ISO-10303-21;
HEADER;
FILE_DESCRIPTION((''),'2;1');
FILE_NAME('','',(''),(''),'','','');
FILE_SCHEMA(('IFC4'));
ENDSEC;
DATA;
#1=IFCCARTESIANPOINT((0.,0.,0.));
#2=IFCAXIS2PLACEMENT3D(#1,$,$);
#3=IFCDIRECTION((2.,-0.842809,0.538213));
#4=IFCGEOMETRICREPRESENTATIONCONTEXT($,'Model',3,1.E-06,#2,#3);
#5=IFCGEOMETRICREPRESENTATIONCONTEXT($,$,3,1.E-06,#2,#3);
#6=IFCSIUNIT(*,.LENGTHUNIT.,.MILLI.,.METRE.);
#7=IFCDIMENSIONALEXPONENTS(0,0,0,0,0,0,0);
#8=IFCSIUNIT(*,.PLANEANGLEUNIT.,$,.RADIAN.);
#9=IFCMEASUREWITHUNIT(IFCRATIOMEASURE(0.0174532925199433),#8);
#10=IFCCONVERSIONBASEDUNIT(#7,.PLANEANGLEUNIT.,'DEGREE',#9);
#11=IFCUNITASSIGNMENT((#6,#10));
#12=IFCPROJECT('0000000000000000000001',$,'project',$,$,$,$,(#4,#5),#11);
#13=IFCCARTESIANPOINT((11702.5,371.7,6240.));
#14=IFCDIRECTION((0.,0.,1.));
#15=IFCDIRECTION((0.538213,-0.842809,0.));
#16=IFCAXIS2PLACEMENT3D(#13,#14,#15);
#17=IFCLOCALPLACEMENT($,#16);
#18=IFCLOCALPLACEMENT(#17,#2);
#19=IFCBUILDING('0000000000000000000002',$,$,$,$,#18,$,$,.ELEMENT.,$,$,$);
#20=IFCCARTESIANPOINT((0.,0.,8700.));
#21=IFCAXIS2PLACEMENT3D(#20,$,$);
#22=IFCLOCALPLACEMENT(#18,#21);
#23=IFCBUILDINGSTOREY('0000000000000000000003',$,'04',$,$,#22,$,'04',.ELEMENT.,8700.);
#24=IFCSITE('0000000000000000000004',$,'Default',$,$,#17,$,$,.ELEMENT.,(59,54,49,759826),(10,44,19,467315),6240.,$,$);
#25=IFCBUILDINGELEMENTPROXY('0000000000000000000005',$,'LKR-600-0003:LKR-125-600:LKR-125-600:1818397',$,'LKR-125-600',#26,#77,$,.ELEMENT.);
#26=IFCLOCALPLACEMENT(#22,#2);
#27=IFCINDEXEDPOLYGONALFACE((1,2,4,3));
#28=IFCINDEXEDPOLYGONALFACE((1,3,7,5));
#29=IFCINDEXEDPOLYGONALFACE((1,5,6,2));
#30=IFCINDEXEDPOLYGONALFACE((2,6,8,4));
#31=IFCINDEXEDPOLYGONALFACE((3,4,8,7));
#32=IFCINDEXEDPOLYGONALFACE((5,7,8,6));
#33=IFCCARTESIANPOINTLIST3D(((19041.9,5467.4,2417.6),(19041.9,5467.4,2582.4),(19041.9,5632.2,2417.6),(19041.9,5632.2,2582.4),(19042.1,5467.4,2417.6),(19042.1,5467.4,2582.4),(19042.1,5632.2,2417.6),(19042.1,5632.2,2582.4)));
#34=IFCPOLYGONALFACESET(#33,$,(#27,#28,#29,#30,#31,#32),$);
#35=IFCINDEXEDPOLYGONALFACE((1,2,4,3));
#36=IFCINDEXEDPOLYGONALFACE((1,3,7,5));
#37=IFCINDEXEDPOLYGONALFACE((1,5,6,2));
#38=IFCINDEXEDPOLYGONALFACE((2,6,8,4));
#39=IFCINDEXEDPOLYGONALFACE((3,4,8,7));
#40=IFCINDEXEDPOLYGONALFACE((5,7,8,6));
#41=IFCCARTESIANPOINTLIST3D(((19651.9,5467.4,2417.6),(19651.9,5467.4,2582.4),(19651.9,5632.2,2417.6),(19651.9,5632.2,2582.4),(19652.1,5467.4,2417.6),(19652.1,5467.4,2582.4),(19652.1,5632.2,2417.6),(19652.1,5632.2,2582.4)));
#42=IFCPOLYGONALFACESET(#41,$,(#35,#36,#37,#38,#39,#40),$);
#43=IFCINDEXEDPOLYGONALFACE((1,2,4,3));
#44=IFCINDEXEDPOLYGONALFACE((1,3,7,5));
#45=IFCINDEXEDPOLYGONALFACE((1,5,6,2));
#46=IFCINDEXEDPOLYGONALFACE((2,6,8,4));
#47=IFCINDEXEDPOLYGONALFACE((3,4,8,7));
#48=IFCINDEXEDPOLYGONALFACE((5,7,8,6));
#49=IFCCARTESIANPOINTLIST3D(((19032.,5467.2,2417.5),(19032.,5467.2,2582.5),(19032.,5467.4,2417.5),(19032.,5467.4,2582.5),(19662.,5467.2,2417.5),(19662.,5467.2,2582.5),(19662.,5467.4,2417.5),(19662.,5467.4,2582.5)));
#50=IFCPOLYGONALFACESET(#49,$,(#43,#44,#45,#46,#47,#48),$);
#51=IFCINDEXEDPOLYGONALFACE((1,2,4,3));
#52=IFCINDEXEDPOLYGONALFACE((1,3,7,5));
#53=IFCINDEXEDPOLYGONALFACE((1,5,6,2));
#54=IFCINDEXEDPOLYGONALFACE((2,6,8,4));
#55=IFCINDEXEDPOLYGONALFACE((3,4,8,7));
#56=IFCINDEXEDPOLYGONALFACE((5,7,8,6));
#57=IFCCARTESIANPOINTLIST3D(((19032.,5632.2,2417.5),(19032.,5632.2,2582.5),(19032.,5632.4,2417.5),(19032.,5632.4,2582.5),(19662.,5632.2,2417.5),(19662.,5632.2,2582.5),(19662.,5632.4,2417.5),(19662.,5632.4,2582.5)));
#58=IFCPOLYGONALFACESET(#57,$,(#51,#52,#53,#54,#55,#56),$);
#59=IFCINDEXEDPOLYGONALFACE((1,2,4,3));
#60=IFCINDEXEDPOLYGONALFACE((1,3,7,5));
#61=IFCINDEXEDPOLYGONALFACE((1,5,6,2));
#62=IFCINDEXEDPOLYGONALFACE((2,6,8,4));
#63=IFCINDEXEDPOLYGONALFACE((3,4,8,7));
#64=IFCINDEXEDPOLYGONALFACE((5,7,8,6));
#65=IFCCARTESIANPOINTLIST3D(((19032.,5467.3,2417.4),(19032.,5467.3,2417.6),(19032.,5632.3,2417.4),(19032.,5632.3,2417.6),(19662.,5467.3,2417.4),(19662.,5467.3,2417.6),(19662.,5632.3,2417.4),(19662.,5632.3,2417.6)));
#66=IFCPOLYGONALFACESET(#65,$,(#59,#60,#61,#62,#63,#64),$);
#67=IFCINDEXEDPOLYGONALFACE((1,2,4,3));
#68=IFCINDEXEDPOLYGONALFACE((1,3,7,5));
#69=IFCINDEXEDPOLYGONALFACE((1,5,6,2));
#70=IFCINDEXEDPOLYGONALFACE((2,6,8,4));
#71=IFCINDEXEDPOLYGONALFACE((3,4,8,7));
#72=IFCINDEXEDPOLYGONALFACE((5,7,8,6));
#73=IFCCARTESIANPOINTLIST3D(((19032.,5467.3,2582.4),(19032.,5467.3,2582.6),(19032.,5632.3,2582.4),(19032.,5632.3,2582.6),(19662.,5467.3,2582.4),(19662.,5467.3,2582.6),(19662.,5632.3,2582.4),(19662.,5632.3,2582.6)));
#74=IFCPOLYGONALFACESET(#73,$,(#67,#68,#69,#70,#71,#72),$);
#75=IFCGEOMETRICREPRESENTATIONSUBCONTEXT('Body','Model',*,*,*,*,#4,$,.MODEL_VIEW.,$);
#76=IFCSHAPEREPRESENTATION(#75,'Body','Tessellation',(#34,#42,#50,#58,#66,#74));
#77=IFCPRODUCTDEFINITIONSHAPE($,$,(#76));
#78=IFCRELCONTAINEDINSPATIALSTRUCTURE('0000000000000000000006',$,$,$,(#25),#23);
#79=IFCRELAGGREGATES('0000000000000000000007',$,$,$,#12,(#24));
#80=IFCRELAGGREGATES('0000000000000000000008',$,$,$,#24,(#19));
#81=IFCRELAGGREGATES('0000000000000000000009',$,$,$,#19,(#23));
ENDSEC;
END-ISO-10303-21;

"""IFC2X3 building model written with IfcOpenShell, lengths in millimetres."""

from ifc_helpers import new_model, entity, si_unit, converted_unit, direction, frame, frame_2d, origin, place, context, subcontext, project, spatial, rectangle, extrude, source, transform, mapped, element, save


model = new_model("IFC2X3")

# Units and contexts
model_context = context("Model", 3, precision=1e-06, world=origin(), true_north=direction((2.0, -0.842809, 0.538213)))
context_of_model = context(None, 3, precision=1e-06, world=origin(), true_north=direction((2.0, -0.842809, 0.538213)))
body_context = subcontext(model_context, "Body", "Model", "MODEL_VIEW")
ifc_project = project(units=[si_unit("LENGTHUNIT", "METRE", prefix="MILLI"), converted_unit("PLANEANGLEUNIT", "DEGREE", entity("IfcRatioMeasure", 0.0174532925199433), si_unit("PLANEANGLEUNIT", "RADIAN"), dimensions=[0, 0, 0, 0, 0, 0, 0])], contexts=[model_context, context_of_model])

# Site, building, storey
site_placement = place(None, frame((11702.5, 371.7, 6240.0), z_axis=(0.0, 0.0, 1.0), x_axis=(0.538213, -0.842809, 0.0)))
site = spatial("IfcSite", under=ifc_project, at=site_placement, Name="Default", CompositionType="ELEMENT", RefLatitude=(59, 54, 49, 759826), RefLongitude=(10, 44, 19, 467315), RefElevation=6240.0)
building_placement = place(site_placement, origin())
building = spatial("IfcBuilding", under=site, at=building_placement, CompositionType="ELEMENT")
storey_placement = place(building_placement, frame((0.0, 0.0, 8700.0)))
storey = spatial("IfcBuildingStorey", under=building, at=storey_placement, Name="04", LongName="04", CompositionType="ELEMENT", Elevation=8700.0)

# Building element proxy
shared_shape_1 = source(origin(), body_context, "Body", "SweptSolid", [
    extrude(rectangle(XDim=0.2, YDim=164.8, at=frame_2d((0.0, 0.0), x_axis=(1.0, 0.0))), frame((305.0, 0.0, -82.4)), (0.0, 0.0, 1.0), 164.8),
    extrude(rectangle(XDim=0.2, YDim=164.8, at=frame_2d((0.0, 0.0), x_axis=(1.0, 0.0))), frame((-305.0, 0.0, -82.4)), (0.0, 0.0, 1.0), 164.8),
    extrude(rectangle(XDim=0.2, YDim=630.0, at=frame_2d((0.0, 0.0), x_axis=(1.0, 0.0))), frame((0.0, 82.5, -82.5), z_axis=(0.0, 0.0, 1.0), x_axis=(0.0, 1.0, 0.0)), (0.0, 0.0, 1.0), 165.0),
    extrude(rectangle(XDim=0.2, YDim=630.0, at=frame_2d((0.0, 0.0), x_axis=(1.0, 0.0))), frame((0.0, -82.5, -82.5), z_axis=(0.0, 0.0, 1.0), x_axis=(0.0, 1.0, 0.0)), (0.0, 0.0, 1.0), 165.0),
    extrude(rectangle(XDim=165.0, YDim=630.0, at=frame_2d((0.0, 0.0), x_axis=(1.0, 0.0))), frame((0.0, 0.0, -82.6), z_axis=(0.0, 0.0, 1.0), x_axis=(0.0, -1.0, 0.0)), (0.0, 0.0, 1.0), 0.2),
    extrude(rectangle(XDim=165.0, YDim=630.0, at=frame_2d((0.0, 0.0), x_axis=(1.0, 0.0))), frame((0.0, 0.0, 82.4), z_axis=(0.0, 0.0, 1.0), x_axis=(0.0, -1.0, 0.0)), (0.0, 0.0, 1.0), 0.2),
])
proxy_1_placement = place(storey_placement, frame((19347.0, 5549.8, 2500.0), z_axis=(0.0, 0.0, 1.0), x_axis=(-1.0, 0.0, 0.0)))
element("IfcBuildingElementProxy", 1, at=proxy_1_placement, inside=storey, Name="LKR-600-0003:LKR-125-600:LKR-125-600:1818397", ObjectType="LKR-125-600", CompositionType="ELEMENT", context=body_context, shape_type="MappedRepresentation", body=[
    mapped(shared_shape_1, transform((0.0, 0.0, 0.0), scale=1.0)),
])

save(model, "model.ifc")
